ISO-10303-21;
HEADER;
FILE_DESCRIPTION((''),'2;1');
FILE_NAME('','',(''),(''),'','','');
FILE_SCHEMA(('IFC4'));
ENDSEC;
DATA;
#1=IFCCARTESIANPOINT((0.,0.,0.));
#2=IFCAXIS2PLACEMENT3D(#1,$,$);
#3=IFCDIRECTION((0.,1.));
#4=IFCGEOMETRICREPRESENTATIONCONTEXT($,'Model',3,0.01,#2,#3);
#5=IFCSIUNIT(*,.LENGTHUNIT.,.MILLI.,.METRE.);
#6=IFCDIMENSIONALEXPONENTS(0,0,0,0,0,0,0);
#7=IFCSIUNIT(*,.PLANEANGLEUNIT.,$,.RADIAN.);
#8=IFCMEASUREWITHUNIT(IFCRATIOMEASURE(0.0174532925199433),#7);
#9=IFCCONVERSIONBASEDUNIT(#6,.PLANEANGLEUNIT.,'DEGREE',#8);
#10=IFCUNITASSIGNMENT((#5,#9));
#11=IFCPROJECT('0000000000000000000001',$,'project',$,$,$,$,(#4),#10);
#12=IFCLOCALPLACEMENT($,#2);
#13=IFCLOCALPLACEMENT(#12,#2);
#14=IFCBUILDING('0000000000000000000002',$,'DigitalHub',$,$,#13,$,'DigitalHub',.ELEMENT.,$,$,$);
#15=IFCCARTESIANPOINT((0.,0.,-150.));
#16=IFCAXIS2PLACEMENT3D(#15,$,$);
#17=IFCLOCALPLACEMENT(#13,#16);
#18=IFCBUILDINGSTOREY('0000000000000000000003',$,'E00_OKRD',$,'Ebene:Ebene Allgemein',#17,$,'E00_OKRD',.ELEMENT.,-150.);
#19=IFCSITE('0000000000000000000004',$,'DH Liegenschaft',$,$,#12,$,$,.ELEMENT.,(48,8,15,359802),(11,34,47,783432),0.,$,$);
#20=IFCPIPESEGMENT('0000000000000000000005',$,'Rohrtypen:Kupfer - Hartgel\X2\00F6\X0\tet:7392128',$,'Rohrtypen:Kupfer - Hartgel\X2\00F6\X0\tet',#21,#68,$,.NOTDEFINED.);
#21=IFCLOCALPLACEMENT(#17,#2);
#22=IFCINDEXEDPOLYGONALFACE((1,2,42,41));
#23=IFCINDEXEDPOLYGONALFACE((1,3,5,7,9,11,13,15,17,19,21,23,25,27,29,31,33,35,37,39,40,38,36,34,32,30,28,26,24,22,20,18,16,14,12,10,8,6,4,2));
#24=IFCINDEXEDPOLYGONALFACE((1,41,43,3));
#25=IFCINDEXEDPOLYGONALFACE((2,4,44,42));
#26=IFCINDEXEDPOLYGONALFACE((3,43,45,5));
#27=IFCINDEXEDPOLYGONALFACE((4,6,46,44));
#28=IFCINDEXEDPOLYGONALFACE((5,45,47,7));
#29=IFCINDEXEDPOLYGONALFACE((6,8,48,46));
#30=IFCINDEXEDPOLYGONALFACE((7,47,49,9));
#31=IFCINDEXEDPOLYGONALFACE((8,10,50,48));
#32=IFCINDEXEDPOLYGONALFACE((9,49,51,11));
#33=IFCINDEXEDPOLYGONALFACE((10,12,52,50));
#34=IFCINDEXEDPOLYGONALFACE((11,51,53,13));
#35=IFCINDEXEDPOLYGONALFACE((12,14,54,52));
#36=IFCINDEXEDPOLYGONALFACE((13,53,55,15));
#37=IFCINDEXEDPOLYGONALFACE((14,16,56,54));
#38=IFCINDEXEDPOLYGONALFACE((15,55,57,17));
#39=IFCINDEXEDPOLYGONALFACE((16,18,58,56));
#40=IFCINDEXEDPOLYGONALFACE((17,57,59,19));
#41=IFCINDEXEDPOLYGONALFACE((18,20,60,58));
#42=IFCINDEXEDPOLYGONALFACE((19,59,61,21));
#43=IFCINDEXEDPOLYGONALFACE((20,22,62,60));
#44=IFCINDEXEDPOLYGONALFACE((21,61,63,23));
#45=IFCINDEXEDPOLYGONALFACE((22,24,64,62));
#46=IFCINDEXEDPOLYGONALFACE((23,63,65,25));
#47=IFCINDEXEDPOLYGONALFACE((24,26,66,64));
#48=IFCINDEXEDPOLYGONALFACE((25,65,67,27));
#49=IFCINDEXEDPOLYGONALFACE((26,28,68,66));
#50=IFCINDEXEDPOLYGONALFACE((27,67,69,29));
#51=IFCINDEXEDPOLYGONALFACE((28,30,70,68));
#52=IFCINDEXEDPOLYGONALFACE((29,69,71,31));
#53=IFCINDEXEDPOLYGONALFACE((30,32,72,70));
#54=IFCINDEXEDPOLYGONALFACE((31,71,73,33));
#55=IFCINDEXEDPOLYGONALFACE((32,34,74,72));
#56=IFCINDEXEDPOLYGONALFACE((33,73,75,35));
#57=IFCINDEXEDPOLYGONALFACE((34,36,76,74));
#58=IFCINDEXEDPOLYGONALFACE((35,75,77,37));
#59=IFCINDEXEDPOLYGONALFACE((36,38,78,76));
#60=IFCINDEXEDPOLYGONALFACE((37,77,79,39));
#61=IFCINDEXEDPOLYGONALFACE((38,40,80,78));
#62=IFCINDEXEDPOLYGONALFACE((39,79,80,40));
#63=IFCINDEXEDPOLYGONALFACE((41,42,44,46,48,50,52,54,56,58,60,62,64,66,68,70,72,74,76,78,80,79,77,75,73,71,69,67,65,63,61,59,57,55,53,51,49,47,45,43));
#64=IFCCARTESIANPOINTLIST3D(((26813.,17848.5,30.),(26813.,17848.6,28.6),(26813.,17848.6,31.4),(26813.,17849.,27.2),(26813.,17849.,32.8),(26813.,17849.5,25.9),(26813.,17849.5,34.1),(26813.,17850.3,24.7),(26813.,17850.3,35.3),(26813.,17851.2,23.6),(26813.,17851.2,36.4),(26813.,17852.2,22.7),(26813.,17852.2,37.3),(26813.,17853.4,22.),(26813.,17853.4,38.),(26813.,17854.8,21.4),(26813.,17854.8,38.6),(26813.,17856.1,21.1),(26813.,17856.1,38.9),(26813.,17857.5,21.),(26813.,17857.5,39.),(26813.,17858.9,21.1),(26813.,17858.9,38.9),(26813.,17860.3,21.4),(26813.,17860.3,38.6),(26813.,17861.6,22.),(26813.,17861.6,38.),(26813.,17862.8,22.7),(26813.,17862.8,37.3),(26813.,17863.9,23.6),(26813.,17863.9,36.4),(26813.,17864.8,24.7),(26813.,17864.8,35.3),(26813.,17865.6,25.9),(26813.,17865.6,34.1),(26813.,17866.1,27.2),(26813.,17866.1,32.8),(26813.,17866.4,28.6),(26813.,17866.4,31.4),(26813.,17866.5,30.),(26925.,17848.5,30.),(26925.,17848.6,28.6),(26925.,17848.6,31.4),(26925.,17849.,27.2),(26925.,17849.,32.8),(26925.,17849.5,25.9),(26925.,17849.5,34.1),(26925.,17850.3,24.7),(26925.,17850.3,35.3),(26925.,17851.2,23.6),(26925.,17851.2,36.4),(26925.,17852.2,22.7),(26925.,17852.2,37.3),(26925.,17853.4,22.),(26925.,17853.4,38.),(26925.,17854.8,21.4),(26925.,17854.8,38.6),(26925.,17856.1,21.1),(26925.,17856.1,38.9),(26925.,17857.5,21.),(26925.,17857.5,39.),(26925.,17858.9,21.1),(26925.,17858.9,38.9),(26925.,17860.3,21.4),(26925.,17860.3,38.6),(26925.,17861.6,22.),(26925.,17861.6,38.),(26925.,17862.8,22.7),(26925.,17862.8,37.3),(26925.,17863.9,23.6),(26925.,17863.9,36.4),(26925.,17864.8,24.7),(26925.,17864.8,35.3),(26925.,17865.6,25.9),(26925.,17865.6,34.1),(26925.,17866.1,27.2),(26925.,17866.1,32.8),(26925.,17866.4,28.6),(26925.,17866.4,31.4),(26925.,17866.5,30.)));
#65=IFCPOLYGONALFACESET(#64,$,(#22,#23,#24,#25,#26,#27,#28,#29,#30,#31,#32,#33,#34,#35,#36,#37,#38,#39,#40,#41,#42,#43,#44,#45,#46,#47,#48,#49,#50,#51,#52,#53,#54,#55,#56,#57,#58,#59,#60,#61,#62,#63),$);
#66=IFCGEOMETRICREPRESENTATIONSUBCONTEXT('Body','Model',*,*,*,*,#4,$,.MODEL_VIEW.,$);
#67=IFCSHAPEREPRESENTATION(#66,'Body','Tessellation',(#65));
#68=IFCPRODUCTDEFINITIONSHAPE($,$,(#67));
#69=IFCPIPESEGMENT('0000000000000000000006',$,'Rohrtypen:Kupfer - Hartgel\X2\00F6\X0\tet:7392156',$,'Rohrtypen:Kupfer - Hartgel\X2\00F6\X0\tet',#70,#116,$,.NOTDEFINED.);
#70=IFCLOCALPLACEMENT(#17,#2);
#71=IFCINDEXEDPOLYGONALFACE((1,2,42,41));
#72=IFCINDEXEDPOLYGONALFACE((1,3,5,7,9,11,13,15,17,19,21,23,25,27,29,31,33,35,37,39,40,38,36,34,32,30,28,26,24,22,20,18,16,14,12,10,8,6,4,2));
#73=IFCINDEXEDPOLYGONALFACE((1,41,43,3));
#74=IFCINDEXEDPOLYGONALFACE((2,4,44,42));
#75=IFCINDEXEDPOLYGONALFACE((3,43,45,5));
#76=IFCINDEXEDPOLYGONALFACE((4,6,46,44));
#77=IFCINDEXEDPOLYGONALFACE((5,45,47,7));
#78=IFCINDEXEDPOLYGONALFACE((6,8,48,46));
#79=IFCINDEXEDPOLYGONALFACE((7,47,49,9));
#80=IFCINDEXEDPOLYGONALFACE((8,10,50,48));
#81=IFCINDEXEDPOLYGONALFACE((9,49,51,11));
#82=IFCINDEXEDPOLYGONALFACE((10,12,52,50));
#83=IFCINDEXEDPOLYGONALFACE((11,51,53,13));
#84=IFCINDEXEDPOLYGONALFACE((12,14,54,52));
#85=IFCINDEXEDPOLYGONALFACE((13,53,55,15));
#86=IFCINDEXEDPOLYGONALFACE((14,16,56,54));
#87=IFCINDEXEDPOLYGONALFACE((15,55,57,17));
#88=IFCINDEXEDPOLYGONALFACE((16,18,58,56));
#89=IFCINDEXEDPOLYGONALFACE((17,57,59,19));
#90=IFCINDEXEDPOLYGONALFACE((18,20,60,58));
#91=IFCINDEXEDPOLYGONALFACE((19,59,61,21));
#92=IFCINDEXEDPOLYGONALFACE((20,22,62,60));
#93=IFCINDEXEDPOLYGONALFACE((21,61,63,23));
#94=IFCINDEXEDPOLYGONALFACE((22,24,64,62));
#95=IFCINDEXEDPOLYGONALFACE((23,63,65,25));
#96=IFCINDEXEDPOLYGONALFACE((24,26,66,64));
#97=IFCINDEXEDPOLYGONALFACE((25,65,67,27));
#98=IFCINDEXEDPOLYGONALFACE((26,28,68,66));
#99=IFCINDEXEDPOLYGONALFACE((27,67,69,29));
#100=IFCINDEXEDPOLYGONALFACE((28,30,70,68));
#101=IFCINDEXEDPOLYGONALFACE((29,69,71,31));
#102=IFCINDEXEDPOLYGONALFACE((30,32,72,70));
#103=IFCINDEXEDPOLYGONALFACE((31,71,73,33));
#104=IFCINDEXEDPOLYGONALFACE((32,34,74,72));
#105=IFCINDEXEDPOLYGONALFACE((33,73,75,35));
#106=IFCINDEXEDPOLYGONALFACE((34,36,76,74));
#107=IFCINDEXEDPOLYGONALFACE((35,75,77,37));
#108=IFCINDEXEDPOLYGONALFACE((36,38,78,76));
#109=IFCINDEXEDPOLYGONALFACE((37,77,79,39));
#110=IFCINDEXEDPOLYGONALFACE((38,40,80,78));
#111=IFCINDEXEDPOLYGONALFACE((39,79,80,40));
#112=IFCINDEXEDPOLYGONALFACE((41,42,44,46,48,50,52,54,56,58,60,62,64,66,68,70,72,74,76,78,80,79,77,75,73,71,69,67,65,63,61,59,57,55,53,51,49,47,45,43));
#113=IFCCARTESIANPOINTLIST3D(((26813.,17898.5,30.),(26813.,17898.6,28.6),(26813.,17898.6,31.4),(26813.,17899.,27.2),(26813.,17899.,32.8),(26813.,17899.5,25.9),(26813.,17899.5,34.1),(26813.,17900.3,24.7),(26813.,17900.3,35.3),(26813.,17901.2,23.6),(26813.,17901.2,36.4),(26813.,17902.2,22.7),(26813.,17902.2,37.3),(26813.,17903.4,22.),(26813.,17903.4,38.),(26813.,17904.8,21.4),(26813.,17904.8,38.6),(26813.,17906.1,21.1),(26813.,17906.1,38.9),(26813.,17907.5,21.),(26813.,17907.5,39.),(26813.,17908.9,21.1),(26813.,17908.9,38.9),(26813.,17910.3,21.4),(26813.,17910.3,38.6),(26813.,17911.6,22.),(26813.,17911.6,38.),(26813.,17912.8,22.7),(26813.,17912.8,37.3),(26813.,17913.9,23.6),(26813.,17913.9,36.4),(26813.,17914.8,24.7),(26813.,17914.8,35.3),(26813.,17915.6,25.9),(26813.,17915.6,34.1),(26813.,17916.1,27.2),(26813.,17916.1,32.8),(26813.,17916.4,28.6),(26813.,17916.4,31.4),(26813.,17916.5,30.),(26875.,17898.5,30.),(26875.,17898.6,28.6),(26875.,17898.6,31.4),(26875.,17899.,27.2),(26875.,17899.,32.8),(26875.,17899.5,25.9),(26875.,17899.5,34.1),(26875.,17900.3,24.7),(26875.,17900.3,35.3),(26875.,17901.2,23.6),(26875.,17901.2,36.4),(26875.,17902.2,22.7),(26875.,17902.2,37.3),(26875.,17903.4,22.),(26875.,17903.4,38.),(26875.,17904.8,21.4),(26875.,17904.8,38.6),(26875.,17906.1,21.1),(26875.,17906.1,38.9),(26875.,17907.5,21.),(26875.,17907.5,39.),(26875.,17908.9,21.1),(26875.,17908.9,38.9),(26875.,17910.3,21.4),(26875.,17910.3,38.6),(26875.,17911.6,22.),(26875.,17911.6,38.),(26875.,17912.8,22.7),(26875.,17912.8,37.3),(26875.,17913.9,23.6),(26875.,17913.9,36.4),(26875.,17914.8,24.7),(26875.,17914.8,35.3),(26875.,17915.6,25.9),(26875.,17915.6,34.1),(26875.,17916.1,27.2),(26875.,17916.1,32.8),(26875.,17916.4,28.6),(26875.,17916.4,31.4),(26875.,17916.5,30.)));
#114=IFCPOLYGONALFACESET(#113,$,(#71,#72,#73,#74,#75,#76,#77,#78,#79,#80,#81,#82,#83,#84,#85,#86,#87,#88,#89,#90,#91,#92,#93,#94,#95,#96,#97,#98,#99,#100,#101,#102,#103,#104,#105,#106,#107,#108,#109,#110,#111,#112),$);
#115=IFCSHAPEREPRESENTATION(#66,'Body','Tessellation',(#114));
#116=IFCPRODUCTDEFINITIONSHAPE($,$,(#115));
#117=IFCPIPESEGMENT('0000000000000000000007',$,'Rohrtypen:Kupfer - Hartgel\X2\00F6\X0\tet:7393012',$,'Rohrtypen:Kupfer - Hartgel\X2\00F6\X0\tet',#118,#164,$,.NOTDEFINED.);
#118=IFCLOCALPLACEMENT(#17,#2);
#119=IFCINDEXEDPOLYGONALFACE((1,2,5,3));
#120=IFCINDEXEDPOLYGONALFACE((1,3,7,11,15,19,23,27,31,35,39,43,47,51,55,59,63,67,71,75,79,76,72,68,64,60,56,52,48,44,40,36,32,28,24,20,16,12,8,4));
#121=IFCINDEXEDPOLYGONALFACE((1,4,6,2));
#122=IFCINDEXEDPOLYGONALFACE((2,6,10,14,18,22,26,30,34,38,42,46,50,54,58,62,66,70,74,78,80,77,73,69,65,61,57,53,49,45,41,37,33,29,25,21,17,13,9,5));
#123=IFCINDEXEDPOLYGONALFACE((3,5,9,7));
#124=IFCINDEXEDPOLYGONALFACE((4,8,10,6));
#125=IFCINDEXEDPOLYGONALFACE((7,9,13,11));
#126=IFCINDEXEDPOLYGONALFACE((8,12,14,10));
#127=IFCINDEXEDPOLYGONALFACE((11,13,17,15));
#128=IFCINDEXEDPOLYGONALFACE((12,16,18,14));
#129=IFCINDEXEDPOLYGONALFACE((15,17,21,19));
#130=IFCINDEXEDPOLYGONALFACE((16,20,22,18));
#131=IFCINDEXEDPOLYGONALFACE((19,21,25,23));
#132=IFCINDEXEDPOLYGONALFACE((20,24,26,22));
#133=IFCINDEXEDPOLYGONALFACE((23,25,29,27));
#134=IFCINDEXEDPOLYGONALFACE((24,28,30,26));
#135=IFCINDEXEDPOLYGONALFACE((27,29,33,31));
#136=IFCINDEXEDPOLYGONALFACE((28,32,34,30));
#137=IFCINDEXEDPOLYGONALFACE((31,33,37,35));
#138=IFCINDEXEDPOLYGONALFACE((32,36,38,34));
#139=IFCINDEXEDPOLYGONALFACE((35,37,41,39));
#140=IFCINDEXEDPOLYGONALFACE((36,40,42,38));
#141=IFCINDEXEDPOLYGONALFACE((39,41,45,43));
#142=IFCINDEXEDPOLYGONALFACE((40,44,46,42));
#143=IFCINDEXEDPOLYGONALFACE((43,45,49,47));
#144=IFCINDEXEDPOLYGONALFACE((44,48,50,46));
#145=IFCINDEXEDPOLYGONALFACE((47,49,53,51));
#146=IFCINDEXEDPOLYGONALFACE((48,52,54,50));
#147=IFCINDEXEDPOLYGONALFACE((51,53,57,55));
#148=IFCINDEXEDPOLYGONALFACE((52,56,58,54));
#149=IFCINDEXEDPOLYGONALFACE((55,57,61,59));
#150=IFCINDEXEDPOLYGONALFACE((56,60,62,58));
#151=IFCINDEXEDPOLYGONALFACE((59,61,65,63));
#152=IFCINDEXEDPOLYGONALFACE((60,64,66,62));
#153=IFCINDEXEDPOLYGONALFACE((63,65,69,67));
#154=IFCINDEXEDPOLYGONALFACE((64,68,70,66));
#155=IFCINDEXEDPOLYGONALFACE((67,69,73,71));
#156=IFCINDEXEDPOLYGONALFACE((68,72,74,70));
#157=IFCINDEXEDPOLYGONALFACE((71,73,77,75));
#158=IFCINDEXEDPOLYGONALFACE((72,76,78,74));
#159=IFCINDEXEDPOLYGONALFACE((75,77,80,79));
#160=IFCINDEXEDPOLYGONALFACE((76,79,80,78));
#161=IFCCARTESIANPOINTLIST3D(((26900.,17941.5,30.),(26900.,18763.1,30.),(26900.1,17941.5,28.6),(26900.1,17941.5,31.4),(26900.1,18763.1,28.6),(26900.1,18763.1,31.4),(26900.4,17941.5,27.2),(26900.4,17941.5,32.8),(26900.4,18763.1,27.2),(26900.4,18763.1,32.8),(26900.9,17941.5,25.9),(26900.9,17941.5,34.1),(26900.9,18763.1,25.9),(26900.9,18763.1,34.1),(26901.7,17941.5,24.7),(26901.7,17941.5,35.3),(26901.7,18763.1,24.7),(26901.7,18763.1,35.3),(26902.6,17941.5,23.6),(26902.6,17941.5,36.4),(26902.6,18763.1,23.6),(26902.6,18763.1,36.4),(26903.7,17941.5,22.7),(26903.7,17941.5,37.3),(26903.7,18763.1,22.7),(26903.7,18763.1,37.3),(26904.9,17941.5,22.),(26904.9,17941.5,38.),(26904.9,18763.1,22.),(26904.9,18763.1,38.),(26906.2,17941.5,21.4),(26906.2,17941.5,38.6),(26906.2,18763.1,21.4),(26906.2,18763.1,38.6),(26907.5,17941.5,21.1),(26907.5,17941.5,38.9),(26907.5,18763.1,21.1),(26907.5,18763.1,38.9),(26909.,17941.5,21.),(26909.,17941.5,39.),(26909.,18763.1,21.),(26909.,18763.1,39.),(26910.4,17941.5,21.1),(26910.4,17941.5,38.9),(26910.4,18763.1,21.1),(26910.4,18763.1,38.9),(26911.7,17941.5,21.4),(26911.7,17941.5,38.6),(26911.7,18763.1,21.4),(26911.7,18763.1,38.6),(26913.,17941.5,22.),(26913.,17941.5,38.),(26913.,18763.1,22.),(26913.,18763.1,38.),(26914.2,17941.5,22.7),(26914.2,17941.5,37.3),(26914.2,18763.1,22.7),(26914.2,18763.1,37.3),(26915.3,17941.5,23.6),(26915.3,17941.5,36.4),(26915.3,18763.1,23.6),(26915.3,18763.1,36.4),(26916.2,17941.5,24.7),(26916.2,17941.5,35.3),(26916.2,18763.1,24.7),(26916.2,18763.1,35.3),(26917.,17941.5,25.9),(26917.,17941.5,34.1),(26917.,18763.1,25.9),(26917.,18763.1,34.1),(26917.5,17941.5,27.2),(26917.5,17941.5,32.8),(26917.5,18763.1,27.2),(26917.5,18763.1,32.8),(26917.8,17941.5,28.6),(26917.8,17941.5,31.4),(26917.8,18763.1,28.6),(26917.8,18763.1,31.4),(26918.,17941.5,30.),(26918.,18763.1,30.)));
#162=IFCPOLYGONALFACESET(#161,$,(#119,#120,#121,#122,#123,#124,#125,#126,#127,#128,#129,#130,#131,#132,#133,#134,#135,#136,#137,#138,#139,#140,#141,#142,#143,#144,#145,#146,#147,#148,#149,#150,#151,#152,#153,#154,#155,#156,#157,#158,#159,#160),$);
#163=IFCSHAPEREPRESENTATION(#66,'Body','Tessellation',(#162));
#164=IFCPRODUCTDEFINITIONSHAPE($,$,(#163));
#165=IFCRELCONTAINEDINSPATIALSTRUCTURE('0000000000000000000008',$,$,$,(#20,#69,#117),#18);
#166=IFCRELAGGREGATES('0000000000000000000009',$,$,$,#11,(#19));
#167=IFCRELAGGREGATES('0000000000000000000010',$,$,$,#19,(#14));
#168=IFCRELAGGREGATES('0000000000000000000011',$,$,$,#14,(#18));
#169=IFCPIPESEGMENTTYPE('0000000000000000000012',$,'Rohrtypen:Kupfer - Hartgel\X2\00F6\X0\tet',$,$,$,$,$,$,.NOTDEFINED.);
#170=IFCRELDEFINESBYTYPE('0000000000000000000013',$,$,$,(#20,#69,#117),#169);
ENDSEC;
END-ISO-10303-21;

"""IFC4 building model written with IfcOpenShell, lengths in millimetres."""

from ifc_helpers import new_model, entity, si_unit, converted_unit, direction, frame, origin, place, context, subcontext, project, spatial, indexed_curve, outline, extrude, type_object, element, save


model = new_model("IFC4")

# Units and contexts
model_context = context("Model", 3, precision=0.01, world=origin(), true_north=direction((0.0, 1.0)))
body_context = subcontext(model_context, "Body", "Model", "MODEL_VIEW")
ifc_project = project(units=[si_unit("LENGTHUNIT", "METRE", prefix="MILLI"), converted_unit("PLANEANGLEUNIT", "DEGREE", entity("IfcRatioMeasure", 0.0174532925199433), si_unit("PLANEANGLEUNIT", "RADIAN"), dimensions=[0, 0, 0, 0, 0, 0, 0])], contexts=[model_context])

# Site, building, storey
site_placement = place(None, origin())
site = spatial("IfcSite", under=ifc_project, at=site_placement, Name="DH Liegenschaft", CompositionType="ELEMENT", RefLatitude=(48, 8, 15, 359802), RefLongitude=(11, 34, 47, 783432), RefElevation=0.0)
building_placement = place(site_placement, origin())
building = spatial("IfcBuilding", under=site, at=building_placement, Name="DigitalHub", LongName="DigitalHub", CompositionType="ELEMENT")
storey_placement = place(building_placement, frame((0.0, 0.0, -150.0)))
storey = spatial("IfcBuildingStorey", under=building, at=storey_placement, Name="E00_OKRD", ObjectType="Ebene:Ebene Allgemein", LongName="E00_OKRD", CompositionType="ELEMENT", Elevation=-150.0)

# Pipe segments
pipe_segment_type = type_object("IfcPipeSegmentType", Name="Rohrtypen:Kupfer - Hartgelötet", PredefinedType="NOTDEFINED")
pipe_segment_1_placement = place(storey_placement, frame((26813.0, 17846.9, 19.4)))
element("IfcPipeSegment", 1, at=pipe_segment_1_placement, inside=storey, type_object=pipe_segment_type, Name="Rohrtypen:Kupfer - Hartgelötet:7392128", ObjectType="Rohrtypen:Kupfer - Hartgelötet", PredefinedType="NOTDEFINED", context=body_context, shape_type="SweptSolid", body=[
    extrude(outline(indexed_curve([(9.0, 0.0), (8.9, 1.4), (8.6, 2.8), (8.0, 4.1), (7.3, 5.3), (6.4, 6.4), (5.3, 7.3), (4.1, 8.0), (2.8, 8.6), (1.4, 8.9), (0.0, 9.0), (-1.4, 8.9), (-2.8, 8.6), (-4.1, 8.0), (-5.3, 7.3), (-6.4, 6.4), (-7.3, 5.3), (-8.0, 4.1), (-8.6, 2.8), (-8.9, 1.4), (-9.0, 0.0), (-8.9, -1.4), (-8.6, -2.8), (-8.0, -4.1), (-7.3, -5.3), (-6.4, -6.4), (-5.3, -7.3), (-4.1, -8.0), (-2.8, -8.6), (-1.4, -8.9), (0.0, -9.0), (1.4, -8.9), (2.8, -8.6), (4.1, -8.0), (5.3, -7.3), (6.4, -6.4), (7.3, -5.3), (8.0, -4.1), (8.6, -2.8), (8.9, -1.4), (9.0, 0.0)], self_intersect=False)), frame((0.0, 10.6, 10.6), z_axis=(1.0, 0.0, 0.0), x_axis=(0.0, -1.0, 0.0)), (0.0, 0.0, 1.0), 112.0),
])
pipe_segment_2_placement = place(storey_placement, frame((26813.0, 17896.9, 19.4)))
element("IfcPipeSegment", 2, at=pipe_segment_2_placement, inside=storey, type_object=pipe_segment_type, Name="Rohrtypen:Kupfer - Hartgelötet:7392156", ObjectType="Rohrtypen:Kupfer - Hartgelötet", PredefinedType="NOTDEFINED", context=body_context, shape_type="SweptSolid", body=[
    extrude(outline(indexed_curve([(9.0, 0.0), (8.9, 1.4), (8.6, 2.8), (8.0, 4.1), (7.3, 5.3), (6.4, 6.4), (5.3, 7.3), (4.1, 8.0), (2.8, 8.6), (1.4, 8.9), (0.0, 9.0), (-1.4, 8.9), (-2.8, 8.6), (-4.1, 8.0), (-5.3, 7.3), (-6.4, 6.4), (-7.3, 5.3), (-8.0, 4.1), (-8.6, 2.8), (-8.9, 1.4), (-9.0, 0.0), (-8.9, -1.4), (-8.6, -2.8), (-8.0, -4.1), (-7.3, -5.3), (-6.4, -6.4), (-5.3, -7.3), (-4.1, -8.0), (-2.8, -8.6), (-1.4, -8.9), (0.0, -9.0), (1.4, -8.9), (2.8, -8.6), (4.1, -8.0), (5.3, -7.3), (6.4, -6.4), (7.3, -5.3), (8.0, -4.1), (8.6, -2.8), (8.9, -1.4), (9.0, 0.0)], self_intersect=False)), frame((0.0, 10.6, 10.6), z_axis=(1.0, 0.0, 0.0), x_axis=(0.0, -1.0, 0.0)), (0.0, 0.0, 1.0), 62.0),
])
pipe_segment_3_placement = place(storey_placement, frame((26898.4, 17941.5, 19.4)))
element("IfcPipeSegment", 3, at=pipe_segment_3_placement, inside=storey, type_object=pipe_segment_type, Name="Rohrtypen:Kupfer - Hartgelötet:7393012", ObjectType="Rohrtypen:Kupfer - Hartgelötet", PredefinedType="NOTDEFINED", context=body_context, shape_type="SweptSolid", body=[
    extrude(outline(indexed_curve([(9.0, 0.0), (8.9, 1.4), (8.6, 2.8), (8.0, 4.1), (7.3, 5.3), (6.4, 6.4), (5.3, 7.3), (4.1, 8.0), (2.8, 8.6), (1.4, 8.9), (0.0, 9.0), (-1.4, 8.9), (-2.8, 8.6), (-4.1, 8.0), (-5.3, 7.3), (-6.4, 6.4), (-7.3, 5.3), (-8.0, 4.1), (-8.6, 2.8), (-8.9, 1.4), (-9.0, 0.0), (-8.9, -1.4), (-8.6, -2.8), (-8.0, -4.1), (-7.3, -5.3), (-6.4, -6.4), (-5.3, -7.3), (-4.1, -8.0), (-2.8, -8.6), (-1.4, -8.9), (0.0, -9.0), (1.4, -8.9), (2.8, -8.6), (4.1, -8.0), (5.3, -7.3), (6.4, -6.4), (7.3, -5.3), (8.0, -4.1), (8.6, -2.8), (8.9, -1.4), (9.0, 0.0)], self_intersect=False)), frame((10.6, 0.0, 10.6), z_axis=(0.0, 1.0, 0.0), x_axis=(1.0, 0.0, 0.0)), (0.0, 0.0, 1.0), 821.5),
])

save(model, "model.ifc")
